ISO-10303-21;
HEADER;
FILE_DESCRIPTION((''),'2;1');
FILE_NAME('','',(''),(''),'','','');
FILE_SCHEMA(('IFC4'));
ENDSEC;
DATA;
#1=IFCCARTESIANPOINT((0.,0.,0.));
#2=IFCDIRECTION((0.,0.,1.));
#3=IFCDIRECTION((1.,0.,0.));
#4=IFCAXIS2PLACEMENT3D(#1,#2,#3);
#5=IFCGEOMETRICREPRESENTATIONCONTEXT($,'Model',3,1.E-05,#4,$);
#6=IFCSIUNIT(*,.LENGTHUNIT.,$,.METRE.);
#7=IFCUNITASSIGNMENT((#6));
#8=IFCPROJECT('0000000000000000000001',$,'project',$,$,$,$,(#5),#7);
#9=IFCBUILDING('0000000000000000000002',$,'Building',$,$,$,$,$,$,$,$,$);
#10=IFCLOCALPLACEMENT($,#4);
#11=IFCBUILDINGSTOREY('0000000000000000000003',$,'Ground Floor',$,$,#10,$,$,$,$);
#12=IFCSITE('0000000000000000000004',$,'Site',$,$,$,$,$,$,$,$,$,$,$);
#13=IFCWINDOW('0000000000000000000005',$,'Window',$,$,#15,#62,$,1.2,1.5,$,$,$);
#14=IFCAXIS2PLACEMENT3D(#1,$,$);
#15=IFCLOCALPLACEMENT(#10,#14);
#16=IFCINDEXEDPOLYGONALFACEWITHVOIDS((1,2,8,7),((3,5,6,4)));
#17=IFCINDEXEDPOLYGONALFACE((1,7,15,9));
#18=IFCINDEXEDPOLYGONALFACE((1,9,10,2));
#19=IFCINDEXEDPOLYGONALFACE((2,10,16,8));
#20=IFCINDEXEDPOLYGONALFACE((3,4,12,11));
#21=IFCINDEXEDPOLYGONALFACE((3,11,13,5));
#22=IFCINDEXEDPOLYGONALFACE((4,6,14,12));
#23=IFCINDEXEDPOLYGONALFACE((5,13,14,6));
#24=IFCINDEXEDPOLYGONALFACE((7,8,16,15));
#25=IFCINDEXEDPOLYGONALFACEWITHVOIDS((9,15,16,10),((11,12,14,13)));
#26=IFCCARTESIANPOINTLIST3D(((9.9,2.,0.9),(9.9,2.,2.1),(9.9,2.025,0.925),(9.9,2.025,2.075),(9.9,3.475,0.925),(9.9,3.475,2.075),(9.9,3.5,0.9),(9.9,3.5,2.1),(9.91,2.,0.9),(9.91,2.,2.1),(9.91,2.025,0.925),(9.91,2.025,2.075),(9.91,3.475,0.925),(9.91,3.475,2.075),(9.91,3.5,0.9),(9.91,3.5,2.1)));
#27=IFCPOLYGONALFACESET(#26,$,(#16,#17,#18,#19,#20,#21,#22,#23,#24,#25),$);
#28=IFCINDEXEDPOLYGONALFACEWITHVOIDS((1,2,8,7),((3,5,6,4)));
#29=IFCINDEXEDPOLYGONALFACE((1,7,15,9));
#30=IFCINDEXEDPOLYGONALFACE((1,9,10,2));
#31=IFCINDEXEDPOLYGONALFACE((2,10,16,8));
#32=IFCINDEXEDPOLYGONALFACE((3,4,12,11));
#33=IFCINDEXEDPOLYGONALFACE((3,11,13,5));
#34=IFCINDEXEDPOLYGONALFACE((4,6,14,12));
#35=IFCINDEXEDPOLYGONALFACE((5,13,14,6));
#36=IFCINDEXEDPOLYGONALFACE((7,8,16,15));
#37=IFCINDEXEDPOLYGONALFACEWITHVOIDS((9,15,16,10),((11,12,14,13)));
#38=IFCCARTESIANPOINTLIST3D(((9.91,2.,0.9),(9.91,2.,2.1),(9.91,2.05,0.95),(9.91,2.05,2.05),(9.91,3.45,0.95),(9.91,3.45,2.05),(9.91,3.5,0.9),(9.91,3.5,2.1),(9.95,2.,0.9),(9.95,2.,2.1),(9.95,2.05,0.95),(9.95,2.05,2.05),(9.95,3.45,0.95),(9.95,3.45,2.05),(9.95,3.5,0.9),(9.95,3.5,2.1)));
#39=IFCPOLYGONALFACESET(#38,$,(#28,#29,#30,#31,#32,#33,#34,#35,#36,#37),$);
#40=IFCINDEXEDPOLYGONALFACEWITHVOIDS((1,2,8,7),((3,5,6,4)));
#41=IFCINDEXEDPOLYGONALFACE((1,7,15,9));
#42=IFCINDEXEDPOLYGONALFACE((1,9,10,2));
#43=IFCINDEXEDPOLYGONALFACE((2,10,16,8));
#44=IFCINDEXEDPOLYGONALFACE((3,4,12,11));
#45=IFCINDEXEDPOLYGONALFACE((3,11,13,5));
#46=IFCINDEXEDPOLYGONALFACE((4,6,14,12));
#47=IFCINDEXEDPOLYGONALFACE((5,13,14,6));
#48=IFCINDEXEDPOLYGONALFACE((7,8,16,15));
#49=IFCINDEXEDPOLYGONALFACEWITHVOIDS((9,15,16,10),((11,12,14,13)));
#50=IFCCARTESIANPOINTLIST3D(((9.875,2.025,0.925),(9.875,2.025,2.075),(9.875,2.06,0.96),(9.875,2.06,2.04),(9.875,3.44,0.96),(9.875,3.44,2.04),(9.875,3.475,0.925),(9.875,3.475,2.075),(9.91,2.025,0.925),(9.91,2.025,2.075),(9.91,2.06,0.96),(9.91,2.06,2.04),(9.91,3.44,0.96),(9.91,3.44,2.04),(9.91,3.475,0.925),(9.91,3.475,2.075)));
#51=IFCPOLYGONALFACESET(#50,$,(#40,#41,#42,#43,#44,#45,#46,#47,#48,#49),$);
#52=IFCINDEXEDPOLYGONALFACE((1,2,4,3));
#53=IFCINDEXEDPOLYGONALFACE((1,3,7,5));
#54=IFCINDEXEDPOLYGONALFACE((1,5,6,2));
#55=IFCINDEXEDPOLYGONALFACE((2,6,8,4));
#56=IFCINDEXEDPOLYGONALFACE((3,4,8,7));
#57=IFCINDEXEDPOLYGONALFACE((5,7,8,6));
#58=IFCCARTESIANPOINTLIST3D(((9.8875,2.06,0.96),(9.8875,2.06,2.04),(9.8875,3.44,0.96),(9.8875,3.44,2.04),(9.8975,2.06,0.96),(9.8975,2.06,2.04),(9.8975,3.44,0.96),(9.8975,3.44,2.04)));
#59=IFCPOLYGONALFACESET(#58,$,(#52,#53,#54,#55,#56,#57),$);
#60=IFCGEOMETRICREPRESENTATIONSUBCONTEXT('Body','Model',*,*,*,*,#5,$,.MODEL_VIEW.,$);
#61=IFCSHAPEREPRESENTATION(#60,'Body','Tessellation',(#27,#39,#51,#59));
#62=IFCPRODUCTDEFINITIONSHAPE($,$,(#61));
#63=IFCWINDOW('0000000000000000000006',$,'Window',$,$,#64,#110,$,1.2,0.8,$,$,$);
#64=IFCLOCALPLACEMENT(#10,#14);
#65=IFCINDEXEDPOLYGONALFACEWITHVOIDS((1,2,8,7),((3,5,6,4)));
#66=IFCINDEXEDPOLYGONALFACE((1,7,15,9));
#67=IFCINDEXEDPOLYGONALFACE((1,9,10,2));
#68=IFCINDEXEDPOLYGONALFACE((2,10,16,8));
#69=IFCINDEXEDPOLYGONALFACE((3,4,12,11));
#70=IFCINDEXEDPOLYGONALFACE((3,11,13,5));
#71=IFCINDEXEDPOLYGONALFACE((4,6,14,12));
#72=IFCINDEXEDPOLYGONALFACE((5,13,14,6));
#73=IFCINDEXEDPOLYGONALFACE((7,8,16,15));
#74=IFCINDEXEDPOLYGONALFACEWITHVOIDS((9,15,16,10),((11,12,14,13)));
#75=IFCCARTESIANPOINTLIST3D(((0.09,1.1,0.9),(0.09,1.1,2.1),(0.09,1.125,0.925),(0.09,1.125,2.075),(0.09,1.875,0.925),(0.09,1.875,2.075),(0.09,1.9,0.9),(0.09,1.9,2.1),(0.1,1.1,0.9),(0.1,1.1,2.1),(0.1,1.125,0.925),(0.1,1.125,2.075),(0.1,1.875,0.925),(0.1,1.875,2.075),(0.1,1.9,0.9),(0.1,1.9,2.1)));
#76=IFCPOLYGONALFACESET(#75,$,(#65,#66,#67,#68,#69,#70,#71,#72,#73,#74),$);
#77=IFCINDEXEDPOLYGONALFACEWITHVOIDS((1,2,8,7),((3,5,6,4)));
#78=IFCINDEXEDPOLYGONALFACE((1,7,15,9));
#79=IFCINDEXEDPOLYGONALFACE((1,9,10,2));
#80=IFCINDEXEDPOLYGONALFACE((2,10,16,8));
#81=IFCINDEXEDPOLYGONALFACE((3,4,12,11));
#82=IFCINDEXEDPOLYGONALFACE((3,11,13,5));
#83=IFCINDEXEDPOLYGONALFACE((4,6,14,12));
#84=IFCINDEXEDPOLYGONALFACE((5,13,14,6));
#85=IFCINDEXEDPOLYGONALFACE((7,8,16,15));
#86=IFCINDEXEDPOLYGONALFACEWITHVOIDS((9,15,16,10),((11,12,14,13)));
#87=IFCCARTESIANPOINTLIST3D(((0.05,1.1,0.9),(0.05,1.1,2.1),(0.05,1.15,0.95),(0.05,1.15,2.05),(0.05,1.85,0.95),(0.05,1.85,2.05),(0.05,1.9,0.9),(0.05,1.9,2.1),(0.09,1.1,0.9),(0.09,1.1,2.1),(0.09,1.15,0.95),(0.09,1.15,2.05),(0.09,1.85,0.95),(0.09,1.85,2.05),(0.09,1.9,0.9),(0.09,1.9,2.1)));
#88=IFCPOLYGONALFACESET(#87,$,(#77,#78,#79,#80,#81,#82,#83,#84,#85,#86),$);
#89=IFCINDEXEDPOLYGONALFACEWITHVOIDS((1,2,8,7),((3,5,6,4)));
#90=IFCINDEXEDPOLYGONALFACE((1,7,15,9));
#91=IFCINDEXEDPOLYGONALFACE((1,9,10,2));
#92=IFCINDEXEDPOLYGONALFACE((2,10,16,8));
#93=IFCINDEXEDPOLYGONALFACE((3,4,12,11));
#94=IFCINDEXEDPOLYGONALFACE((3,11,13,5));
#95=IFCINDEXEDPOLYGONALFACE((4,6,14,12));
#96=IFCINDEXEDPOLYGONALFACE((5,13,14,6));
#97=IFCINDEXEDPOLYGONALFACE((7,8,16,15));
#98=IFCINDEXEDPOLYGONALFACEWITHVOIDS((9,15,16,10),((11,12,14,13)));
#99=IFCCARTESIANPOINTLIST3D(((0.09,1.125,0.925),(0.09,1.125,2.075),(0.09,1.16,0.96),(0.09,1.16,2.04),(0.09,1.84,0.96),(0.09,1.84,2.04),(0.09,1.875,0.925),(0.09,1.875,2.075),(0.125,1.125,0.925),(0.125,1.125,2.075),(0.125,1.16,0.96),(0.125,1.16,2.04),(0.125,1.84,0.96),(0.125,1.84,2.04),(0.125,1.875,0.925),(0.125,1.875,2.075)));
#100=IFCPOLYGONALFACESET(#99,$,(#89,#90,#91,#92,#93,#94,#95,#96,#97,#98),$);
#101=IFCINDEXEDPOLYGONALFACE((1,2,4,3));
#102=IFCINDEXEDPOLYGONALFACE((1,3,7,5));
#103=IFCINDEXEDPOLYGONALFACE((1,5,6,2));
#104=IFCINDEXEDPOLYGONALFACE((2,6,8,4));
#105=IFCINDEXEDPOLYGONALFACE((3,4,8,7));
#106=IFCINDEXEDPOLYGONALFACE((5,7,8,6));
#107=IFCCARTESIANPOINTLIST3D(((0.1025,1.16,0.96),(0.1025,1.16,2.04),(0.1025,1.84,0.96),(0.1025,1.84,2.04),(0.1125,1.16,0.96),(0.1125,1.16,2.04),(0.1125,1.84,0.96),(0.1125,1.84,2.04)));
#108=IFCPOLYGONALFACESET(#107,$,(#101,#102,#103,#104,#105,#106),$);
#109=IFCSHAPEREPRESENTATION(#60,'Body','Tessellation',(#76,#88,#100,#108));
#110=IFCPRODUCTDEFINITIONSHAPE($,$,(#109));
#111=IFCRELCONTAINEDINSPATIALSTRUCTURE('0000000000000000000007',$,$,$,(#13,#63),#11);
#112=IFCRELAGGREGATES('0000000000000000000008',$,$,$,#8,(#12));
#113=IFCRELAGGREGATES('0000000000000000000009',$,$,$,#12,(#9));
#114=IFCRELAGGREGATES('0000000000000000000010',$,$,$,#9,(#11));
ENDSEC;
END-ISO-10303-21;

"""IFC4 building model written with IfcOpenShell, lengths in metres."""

from ifc_helpers import new_model, si_unit, frame, origin_with_axes, place, context, subcontext, project, spatial, line, indexed_curve, outline, extrude, element, save


model = new_model("IFC4")

# Units and contexts
model_context = context("Model", 3, precision=1e-05, world=origin_with_axes())
body_context = subcontext(model_context, "Body", "Model", "MODEL_VIEW")
ifc_project = project(units=[si_unit("LENGTHUNIT", "METRE")], contexts=[model_context])

# Site, building, storey
site = spatial("IfcSite", under=ifc_project, Name="Site")
building = spatial("IfcBuilding", under=site, Name="Building")
storey_placement = place(None, origin_with_axes())
storey = spatial("IfcBuildingStorey", under=building, at=storey_placement, Name="Ground Floor")

# Windows
window_1_placement = place(storey_placement, frame((10.0, 2.0, 0.9), z_axis=(0.0, 0.0, 1.0), x_axis=(0.0, 1.0, 0.0)))
element("IfcWindow", 1, at=window_1_placement, inside=storey, Name="Window", OverallHeight=1.2, OverallWidth=1.5, context=body_context, shape_type="SweptSolid", body=[
    extrude(outline(indexed_curve([(0.0, 0.0), (1.5, 0.0), (1.5, 1.2), (0.0, 1.2)], segments=[line(1, 2, 3, 4, 1)]), holes=[indexed_curve([(0.025, 0.025), (1.475, 0.025), (1.475, 1.175), (0.025, 1.175)], segments=[line(1, 2, 3, 4, 1)])]), frame((0.0, 0.09, 0.0), z_axis=(0.0, -1.0, 0.0), x_axis=(1.0, 0.0, 0.0)), (0.0, 0.0, -1.0), 0.01),
    extrude(outline(indexed_curve([(0.0, 0.0), (1.5, 0.0), (1.5, 1.2), (0.0, 1.2)], segments=[line(1, 2, 3, 4, 1)]), holes=[indexed_curve([(0.05, 0.05), (1.45, 0.05), (1.45, 1.15), (0.05, 1.15)], segments=[line(1, 2, 3, 4, 1)])]), frame((0.0, 0.05, 0.0), z_axis=(0.0, -1.0, 0.0), x_axis=(1.0, 0.0, 0.0)), (0.0, 0.0, -1.0), 0.04),
    extrude(outline(indexed_curve([(0.0, 0.0), (1.45, 0.0), (1.45, 1.15), (0.0, 1.15)], segments=[line(1, 2, 3, 4, 1)]), holes=[indexed_curve([(0.035, 0.035), (1.415, 0.035), (1.415, 1.115), (0.035, 1.115)], segments=[line(1, 2, 3, 4, 1)])]), frame((0.025, 0.09, 0.025), z_axis=(0.0, -1.0, 0.0), x_axis=(1.0, 0.0, 0.0)), (0.0, 0.0, -1.0), 0.035),
    extrude(outline(indexed_curve([(0.035, 0.035), (1.415, 0.035), (1.415, 1.115), (0.035, 1.115)], segments=[line(1, 2, 3, 4, 1)])), frame((0.025, 0.1025, 0.025), z_axis=(0.0, -1.0, 0.0), x_axis=(1.0, 0.0, 0.0)), (0.0, 0.0, -1.0), 0.01),
])
window_2_placement = place(storey_placement, frame((0.0, 1.9, 0.9), z_axis=(0.0, 0.0, 1.0), x_axis=(0.0, -1.0, 0.0)))
element("IfcWindow", 2, at=window_2_placement, inside=storey, Name="Window", OverallHeight=1.2, OverallWidth=0.8, context=body_context, shape_type="SweptSolid", body=[
    extrude(outline(indexed_curve([(0.0, 0.0), (0.8, 0.0), (0.8, 1.2), (0.0, 1.2)], segments=[line(1, 2, 3, 4, 1)]), holes=[indexed_curve([(0.025, 0.025), (0.775, 0.025), (0.775, 1.175), (0.025, 1.175)], segments=[line(1, 2, 3, 4, 1)])]), frame((0.0, 0.09, 0.0), z_axis=(0.0, -1.0, 0.0), x_axis=(1.0, 0.0, 0.0)), (0.0, 0.0, -1.0), 0.01),
    extrude(outline(indexed_curve([(0.0, 0.0), (0.8, 0.0), (0.8, 1.2), (0.0, 1.2)], segments=[line(1, 2, 3, 4, 1)]), holes=[indexed_curve([(0.05, 0.05), (0.75, 0.05), (0.75, 1.15), (0.05, 1.15)], segments=[line(1, 2, 3, 4, 1)])]), frame((0.0, 0.05, 0.0), z_axis=(0.0, -1.0, 0.0), x_axis=(1.0, 0.0, 0.0)), (0.0, 0.0, -1.0), 0.04),
    extrude(outline(indexed_curve([(0.0, 0.0), (0.75, 0.0), (0.75, 1.15), (0.0, 1.15)], segments=[line(1, 2, 3, 4, 1)]), holes=[indexed_curve([(0.035, 0.035), (0.715, 0.035), (0.715, 1.115), (0.035, 1.115)], segments=[line(1, 2, 3, 4, 1)])]), frame((0.025, 0.09, 0.025), z_axis=(0.0, -1.0, 0.0), x_axis=(1.0, 0.0, 0.0)), (0.0, 0.0, -1.0), 0.035),
    extrude(outline(indexed_curve([(0.035, 0.035), (0.715, 0.035), (0.715, 1.115), (0.035, 1.115)], segments=[line(1, 2, 3, 4, 1)])), frame((0.025, 0.1025, 0.025), z_axis=(0.0, -1.0, 0.0), x_axis=(1.0, 0.0, 0.0)), (0.0, 0.0, -1.0), 0.01),
])

save(model, "model.ifc")
